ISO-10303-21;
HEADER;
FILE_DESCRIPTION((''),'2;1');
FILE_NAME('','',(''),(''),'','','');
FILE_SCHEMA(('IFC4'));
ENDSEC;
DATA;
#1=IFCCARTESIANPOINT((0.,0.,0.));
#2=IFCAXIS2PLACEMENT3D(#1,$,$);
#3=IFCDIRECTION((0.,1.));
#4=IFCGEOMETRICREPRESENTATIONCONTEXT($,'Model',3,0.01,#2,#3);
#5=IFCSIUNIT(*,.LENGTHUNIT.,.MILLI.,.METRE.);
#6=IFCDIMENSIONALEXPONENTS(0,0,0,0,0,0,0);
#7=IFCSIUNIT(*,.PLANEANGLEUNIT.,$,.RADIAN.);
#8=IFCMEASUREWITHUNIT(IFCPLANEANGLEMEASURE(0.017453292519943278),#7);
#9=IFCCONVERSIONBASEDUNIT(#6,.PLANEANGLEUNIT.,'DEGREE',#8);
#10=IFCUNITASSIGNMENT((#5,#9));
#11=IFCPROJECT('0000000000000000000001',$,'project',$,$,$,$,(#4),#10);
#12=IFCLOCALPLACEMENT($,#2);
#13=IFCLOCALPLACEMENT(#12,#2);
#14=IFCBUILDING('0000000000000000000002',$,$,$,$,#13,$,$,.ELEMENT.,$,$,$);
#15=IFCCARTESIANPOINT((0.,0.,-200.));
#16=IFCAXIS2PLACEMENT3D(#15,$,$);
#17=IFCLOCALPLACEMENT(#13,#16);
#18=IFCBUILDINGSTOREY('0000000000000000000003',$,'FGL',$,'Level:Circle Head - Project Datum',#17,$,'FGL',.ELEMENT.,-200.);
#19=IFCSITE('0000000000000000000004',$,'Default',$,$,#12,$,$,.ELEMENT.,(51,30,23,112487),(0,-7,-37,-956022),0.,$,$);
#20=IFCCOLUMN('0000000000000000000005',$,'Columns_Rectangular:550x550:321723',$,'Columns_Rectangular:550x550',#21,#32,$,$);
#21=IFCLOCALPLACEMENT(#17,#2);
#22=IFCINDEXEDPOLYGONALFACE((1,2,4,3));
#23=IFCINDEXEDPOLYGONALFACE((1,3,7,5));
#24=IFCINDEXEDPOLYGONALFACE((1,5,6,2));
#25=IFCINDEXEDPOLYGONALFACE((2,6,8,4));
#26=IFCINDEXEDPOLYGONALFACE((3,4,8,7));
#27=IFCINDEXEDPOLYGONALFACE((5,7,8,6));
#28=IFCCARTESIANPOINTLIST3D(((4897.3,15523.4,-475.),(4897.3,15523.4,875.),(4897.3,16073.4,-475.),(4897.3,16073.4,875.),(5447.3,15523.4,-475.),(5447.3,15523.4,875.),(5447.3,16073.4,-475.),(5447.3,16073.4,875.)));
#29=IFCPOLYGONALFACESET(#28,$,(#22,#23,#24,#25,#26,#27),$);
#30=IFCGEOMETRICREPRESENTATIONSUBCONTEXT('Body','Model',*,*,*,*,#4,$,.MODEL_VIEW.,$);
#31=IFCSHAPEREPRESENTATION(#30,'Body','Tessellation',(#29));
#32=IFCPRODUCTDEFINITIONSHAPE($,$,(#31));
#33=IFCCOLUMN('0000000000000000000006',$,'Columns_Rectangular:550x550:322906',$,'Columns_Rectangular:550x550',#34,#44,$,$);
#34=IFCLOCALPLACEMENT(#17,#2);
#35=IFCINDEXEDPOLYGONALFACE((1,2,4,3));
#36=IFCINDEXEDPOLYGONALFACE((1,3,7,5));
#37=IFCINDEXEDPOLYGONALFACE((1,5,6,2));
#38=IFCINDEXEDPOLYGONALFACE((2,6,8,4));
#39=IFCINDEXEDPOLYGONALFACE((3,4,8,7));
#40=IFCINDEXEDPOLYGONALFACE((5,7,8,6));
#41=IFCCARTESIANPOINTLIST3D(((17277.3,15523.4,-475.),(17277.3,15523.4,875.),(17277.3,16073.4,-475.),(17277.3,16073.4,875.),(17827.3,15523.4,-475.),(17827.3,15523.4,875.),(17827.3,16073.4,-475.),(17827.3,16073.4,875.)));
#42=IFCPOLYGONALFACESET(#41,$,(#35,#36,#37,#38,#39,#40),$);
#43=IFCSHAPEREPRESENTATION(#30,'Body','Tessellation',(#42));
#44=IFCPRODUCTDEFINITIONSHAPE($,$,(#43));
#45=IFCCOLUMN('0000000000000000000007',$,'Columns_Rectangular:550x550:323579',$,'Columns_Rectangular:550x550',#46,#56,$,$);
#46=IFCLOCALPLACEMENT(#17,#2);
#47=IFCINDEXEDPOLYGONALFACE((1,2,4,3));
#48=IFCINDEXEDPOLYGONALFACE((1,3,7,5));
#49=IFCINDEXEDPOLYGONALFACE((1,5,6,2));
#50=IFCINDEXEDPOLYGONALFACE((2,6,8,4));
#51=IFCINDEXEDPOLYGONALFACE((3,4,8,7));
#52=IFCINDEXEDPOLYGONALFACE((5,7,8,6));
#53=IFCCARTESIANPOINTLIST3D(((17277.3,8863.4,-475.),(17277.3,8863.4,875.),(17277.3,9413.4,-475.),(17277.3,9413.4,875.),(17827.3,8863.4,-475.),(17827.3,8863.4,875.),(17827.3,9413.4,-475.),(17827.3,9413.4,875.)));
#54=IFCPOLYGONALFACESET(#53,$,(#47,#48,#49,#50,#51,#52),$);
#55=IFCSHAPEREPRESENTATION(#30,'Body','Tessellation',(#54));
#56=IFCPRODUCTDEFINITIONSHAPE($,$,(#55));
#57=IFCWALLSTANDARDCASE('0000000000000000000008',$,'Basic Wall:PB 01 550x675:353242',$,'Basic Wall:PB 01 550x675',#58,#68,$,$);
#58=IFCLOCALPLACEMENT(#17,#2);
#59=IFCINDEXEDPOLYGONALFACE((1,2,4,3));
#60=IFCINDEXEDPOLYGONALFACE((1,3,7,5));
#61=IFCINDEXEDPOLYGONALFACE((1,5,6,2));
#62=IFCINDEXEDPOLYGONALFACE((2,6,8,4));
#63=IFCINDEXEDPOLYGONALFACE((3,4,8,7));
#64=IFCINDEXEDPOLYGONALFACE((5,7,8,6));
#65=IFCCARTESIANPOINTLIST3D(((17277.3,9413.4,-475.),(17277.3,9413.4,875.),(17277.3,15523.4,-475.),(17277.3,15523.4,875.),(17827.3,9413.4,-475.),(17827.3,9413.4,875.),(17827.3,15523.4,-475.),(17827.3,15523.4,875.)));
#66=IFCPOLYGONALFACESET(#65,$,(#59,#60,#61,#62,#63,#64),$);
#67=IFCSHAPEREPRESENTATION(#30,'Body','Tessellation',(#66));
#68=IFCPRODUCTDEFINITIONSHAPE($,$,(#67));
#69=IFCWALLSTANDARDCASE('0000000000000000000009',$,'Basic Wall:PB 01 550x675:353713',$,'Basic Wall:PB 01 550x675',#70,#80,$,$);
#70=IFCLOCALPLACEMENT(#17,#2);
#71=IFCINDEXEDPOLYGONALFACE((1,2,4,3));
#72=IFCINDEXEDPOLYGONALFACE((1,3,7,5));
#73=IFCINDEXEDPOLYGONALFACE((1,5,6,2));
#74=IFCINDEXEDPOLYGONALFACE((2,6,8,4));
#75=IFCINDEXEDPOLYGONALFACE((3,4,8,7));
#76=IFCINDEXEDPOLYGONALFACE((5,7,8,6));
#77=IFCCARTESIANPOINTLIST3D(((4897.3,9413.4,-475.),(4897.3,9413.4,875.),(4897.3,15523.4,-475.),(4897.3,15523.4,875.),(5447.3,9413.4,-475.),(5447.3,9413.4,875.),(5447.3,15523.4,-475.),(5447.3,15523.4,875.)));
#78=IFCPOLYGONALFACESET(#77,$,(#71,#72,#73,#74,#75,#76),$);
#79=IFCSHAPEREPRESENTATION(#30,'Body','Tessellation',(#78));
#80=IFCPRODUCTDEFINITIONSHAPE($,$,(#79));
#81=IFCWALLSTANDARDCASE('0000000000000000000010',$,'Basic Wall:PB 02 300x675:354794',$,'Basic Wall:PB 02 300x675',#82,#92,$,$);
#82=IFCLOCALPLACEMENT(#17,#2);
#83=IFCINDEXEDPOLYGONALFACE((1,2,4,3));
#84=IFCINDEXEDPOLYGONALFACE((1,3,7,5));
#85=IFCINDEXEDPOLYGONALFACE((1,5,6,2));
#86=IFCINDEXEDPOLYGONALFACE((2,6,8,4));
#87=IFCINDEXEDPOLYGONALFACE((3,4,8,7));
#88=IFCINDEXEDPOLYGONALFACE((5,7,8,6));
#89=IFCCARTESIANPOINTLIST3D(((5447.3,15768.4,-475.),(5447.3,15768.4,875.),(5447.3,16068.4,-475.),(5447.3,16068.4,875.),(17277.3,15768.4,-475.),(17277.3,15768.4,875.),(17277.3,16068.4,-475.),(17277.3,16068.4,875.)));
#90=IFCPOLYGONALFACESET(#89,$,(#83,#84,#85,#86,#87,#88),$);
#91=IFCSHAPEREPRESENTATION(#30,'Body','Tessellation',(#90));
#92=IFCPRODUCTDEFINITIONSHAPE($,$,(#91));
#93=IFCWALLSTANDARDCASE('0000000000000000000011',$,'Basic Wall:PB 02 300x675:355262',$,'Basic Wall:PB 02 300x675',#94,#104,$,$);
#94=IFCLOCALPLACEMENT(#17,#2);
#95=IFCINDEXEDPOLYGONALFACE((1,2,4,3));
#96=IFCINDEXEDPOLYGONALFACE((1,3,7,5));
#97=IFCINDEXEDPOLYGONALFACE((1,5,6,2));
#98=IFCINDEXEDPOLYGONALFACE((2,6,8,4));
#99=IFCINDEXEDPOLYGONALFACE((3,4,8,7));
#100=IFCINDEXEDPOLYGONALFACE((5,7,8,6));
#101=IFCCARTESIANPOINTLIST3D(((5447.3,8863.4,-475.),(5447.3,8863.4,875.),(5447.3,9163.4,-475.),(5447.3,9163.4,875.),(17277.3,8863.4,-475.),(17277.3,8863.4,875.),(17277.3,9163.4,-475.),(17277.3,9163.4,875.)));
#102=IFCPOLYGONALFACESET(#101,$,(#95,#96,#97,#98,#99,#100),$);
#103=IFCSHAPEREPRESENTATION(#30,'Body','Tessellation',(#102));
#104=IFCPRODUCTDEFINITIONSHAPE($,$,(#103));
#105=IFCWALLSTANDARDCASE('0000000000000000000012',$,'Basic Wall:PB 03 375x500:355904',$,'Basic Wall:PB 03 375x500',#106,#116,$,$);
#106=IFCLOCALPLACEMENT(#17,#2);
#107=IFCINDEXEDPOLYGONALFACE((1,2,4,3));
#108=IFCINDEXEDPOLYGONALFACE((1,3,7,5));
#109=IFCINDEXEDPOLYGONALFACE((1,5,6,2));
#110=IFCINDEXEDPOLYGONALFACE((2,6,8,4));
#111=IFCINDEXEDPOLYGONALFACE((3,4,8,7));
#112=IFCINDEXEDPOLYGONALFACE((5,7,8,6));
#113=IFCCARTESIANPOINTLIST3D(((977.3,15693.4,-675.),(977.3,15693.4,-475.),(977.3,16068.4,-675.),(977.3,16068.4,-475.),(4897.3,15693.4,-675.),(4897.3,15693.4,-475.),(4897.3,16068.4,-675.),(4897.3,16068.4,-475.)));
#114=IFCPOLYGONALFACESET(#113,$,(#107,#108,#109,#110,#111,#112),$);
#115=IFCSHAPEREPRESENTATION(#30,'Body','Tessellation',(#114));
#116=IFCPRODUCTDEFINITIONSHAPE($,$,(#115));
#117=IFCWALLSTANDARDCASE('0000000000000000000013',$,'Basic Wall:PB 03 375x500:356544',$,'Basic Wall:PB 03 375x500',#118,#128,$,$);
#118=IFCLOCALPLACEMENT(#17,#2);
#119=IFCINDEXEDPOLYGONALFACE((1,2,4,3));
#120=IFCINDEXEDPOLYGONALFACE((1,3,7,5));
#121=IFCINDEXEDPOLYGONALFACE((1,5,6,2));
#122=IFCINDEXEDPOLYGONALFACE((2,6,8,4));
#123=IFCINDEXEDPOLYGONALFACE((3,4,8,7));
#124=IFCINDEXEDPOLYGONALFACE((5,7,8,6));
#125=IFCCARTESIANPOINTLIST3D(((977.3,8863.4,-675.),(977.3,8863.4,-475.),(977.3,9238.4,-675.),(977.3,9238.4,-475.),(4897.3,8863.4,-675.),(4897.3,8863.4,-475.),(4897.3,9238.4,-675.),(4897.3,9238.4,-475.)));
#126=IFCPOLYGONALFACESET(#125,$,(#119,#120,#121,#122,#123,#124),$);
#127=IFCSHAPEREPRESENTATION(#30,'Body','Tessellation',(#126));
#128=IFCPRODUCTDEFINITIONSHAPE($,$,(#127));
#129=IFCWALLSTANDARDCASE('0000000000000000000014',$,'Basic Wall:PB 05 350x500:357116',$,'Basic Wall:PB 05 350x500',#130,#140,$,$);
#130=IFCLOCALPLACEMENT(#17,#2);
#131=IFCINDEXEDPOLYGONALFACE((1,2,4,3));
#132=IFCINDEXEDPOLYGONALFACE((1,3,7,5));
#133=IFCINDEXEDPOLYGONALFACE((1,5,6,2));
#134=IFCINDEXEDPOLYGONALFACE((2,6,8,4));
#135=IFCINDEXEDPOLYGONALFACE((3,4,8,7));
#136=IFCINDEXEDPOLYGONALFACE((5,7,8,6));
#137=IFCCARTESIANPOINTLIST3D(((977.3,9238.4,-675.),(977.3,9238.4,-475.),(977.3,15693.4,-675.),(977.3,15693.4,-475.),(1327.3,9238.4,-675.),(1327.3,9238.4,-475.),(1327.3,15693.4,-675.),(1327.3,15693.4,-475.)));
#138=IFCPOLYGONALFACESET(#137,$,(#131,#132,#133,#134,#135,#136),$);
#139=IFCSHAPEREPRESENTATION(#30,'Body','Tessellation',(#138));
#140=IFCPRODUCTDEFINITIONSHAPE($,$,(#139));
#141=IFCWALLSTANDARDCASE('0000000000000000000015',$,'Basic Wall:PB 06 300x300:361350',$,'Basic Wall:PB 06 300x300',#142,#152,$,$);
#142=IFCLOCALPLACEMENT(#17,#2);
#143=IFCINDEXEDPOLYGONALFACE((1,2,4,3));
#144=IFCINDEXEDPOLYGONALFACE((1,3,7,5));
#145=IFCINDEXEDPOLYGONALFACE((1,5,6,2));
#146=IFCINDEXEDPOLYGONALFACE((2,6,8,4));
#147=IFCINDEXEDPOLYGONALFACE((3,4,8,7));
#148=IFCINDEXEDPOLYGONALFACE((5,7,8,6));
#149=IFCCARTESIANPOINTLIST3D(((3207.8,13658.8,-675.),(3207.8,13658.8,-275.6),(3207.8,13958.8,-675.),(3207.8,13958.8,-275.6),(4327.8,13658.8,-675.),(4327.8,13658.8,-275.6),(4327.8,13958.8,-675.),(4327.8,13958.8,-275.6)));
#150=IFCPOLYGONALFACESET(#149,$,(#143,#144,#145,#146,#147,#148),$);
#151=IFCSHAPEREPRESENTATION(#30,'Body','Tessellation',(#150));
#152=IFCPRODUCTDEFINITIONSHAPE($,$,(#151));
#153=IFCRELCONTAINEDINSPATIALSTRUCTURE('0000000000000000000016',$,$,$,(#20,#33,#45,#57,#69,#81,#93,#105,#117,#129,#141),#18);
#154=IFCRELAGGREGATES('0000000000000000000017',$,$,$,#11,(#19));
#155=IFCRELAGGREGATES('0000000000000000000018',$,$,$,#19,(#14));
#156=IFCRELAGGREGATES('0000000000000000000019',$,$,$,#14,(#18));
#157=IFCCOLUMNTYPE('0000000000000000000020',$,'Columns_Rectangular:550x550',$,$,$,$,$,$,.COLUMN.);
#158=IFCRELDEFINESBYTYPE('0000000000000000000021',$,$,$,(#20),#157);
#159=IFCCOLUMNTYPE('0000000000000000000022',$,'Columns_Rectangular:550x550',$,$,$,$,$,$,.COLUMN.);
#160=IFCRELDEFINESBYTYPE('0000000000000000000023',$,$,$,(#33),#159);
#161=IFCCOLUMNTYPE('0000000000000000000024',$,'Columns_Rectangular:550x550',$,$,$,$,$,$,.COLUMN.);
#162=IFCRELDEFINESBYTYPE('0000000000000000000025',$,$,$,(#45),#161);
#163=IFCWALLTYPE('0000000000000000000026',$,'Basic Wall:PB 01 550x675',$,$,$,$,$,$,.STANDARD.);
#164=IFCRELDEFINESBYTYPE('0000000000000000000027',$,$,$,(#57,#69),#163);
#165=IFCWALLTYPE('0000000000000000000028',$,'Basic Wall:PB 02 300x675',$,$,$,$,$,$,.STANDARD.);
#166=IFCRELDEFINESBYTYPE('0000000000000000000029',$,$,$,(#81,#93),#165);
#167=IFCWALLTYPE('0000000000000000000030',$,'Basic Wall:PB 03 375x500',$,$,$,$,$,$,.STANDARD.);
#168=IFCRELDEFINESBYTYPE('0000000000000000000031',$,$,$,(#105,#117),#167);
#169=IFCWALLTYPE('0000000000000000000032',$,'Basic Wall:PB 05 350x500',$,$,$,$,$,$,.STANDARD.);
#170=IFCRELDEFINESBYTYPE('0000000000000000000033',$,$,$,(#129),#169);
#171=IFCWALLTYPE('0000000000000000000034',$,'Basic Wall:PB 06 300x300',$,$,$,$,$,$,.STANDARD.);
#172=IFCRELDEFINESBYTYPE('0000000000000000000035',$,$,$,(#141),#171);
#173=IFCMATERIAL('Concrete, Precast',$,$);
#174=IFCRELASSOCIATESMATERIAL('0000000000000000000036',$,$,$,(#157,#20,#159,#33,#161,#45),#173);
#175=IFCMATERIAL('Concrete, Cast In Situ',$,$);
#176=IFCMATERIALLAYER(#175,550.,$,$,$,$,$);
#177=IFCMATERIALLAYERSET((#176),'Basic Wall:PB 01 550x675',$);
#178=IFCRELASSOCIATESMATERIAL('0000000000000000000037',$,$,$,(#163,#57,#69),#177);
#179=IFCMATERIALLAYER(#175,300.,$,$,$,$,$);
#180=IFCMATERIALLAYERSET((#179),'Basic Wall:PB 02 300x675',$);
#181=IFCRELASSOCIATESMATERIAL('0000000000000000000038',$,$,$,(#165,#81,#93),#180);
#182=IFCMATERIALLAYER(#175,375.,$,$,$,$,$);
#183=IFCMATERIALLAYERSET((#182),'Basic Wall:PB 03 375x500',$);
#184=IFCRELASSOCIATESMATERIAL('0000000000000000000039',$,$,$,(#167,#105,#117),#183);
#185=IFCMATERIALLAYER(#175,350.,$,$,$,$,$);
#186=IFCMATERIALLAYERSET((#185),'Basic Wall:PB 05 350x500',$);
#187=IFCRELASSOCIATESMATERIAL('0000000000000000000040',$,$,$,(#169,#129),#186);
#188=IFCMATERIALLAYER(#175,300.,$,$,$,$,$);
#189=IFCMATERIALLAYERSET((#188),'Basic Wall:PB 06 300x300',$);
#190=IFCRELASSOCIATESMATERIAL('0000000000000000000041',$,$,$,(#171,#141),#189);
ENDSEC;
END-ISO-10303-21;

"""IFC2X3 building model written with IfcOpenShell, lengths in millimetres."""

from ifc_helpers import new_model, entity, si_unit, converted_unit, direction, frame, frame_2d, origin, place, context, subcontext, project, spatial, rectangle, extrude, source, transform, mapped, material, layer, layer_set, layer_usage, type_object, type_shapes, element, save


model = new_model("IFC2X3")

# Units and contexts
model_context = context("Model", 3, precision=0.01, world=origin(), true_north=direction((0.0, 1.0)))
body_context = subcontext(model_context, "Body", "Model", "MODEL_VIEW")
ifc_project = project(units=[si_unit("LENGTHUNIT", "METRE", prefix="MILLI"), converted_unit("PLANEANGLEUNIT", "DEGREE", entity("IfcPlaneAngleMeasure", 0.017453292519943278), si_unit("PLANEANGLEUNIT", "RADIAN"), dimensions=[0, 0, 0, 0, 0, 0, 0])], contexts=[model_context])

# Site, building, storey
site_placement = place(None, origin())
site = spatial("IfcSite", under=ifc_project, at=site_placement, Name="Default", CompositionType="ELEMENT", RefLatitude=(51, 30, 23, 112487), RefLongitude=(0, -7, -37, -956022), RefElevation=0.0)
building_placement = place(site_placement, origin())
building = spatial("IfcBuilding", under=site, at=building_placement, CompositionType="ELEMENT")
storey_placement = place(building_placement, frame((0.0, 0.0, -200.0)))
storey = spatial("IfcBuildingStorey", under=building, at=storey_placement, Name="FGL", ObjectType="Level:Circle Head - Project Datum", LongName="FGL", CompositionType="ELEMENT", Elevation=-200.0)

# Columns
ifc_material_1 = material(Name="Concrete, Precast")
column_type_1 = type_object("IfcColumnType", Name="Columns_Rectangular:550x550", PredefinedType="COLUMN", material=ifc_material_1)
shared_shape_1 = source(origin(), body_context, "Body", "SweptSolid", [
    extrude(rectangle(XDim=550.0, YDim=550.0, at=frame_2d((0.0, 0.0), x_axis=(1.0, 0.0))), frame((5172.3, 15798.4, -675.0), z_axis=(0.0, 0.0, 1.0), x_axis=(-1.0, 0.0, 0.0)), (0.0, 0.0, 1.0), 1350.0),
])
type_shapes(column_type_1, [shared_shape_1])
column_1_placement = place(storey_placement, frame((0.0, 0.0, 200.0)))
element("IfcColumn", 1, at=column_1_placement, inside=storey, type_object=column_type_1, material=ifc_material_1, Name="Columns_Rectangular:550x550:321723", ObjectType="Columns_Rectangular:550x550", context=body_context, shape_type="MappedRepresentation", body=[
    mapped(shared_shape_1, transform((0.0, 0.0, 0.0), scale=1.0)),
])
column_type_2 = type_object("IfcColumnType", Name="Columns_Rectangular:550x550", PredefinedType="COLUMN", material=ifc_material_1)
shared_shape_2 = source(origin(), body_context, "Body", "SweptSolid", [
    extrude(rectangle(XDim=550.0, YDim=550.0, at=frame_2d((0.0, 0.0), x_axis=(1.0, 0.0))), frame((17552.3, 15798.4, -675.0), z_axis=(0.0, 0.0, 1.0), x_axis=(-1.0, 0.0, 0.0)), (0.0, 0.0, 1.0), 1350.0),
])
type_shapes(column_type_2, [shared_shape_2])
column_2_placement = place(storey_placement, frame((0.0, 0.0, 200.0)))
element("IfcColumn", 2, at=column_2_placement, inside=storey, type_object=column_type_2, material=ifc_material_1, Name="Columns_Rectangular:550x550:322906", ObjectType="Columns_Rectangular:550x550", context=body_context, shape_type="MappedRepresentation", body=[
    mapped(shared_shape_2, transform((0.0, 0.0, 0.0), scale=1.0)),
])
column_type_3 = type_object("IfcColumnType", Name="Columns_Rectangular:550x550", PredefinedType="COLUMN", material=ifc_material_1)
shared_shape_3 = source(origin(), body_context, "Body", "SweptSolid", [
    extrude(rectangle(XDim=550.0, YDim=550.0, at=frame_2d((0.0, 0.0), x_axis=(1.0, 0.0))), frame((17552.3, 9138.4, -675.0), z_axis=(0.0, 0.0, 1.0), x_axis=(-1.0, 0.0, 0.0)), (0.0, 0.0, 1.0), 1350.0),
])
type_shapes(column_type_3, [shared_shape_3])
column_3_placement = place(storey_placement, frame((0.0, 0.0, 200.0)))
element("IfcColumn", 3, at=column_3_placement, inside=storey, type_object=column_type_3, material=ifc_material_1, Name="Columns_Rectangular:550x550:323579", ObjectType="Columns_Rectangular:550x550", context=body_context, shape_type="MappedRepresentation", body=[
    mapped(shared_shape_3, transform((0.0, 0.0, 0.0), scale=1.0)),
])

# Walls
ifc_material_2 = material(Name="Concrete, Cast In Situ")
ifc_layer_1 = layer(ifc_material_2, 550.0)
ifc_layer_set_1 = layer_set([ifc_layer_1], Name="Basic Wall:PB 01 550x675")
ifc_layer_usage_1 = layer_usage(ifc_layer_set_1, "AXIS2", "NEGATIVE", 275.0)
wall_type_1 = type_object("IfcWallType", Name="Basic Wall:PB 01 550x675", PredefinedType="STANDARD", material=ifc_layer_set_1)
wall_1_placement = place(storey_placement, frame((17552.3, 15523.4, -475.0), z_axis=(0.0, 0.0, 1.0), x_axis=(0.0, -1.0, 0.0)))
element("IfcWallStandardCase", 4, at=wall_1_placement, inside=storey, type_object=wall_type_1, material=ifc_layer_usage_1, Name="Basic Wall:PB 01 550x675:353242", ObjectType="Basic Wall:PB 01 550x675", context=body_context, shape_type="SweptSolid", body=[
    extrude(rectangle(XDim=6110.0, YDim=550.0, at=frame_2d((3055.0, 0.0), x_axis=(-1.0, 0.0))), origin(), (0.0, 0.0, 1.0), 1350.0),
])
ifc_layer_usage_2 = layer_usage(ifc_layer_set_1, "AXIS2", "NEGATIVE", 275.0)
wall_2_placement = place(storey_placement, frame((5172.3, 15523.4, -475.0), z_axis=(0.0, 0.0, 1.0), x_axis=(0.0, -1.0, 0.0)))
element("IfcWallStandardCase", 5, at=wall_2_placement, inside=storey, type_object=wall_type_1, material=ifc_layer_usage_2, Name="Basic Wall:PB 01 550x675:353713", ObjectType="Basic Wall:PB 01 550x675", context=body_context, shape_type="SweptSolid", body=[
    extrude(rectangle(XDim=6110.0, YDim=550.0, at=frame_2d((3055.0, 0.0), x_axis=(-1.0, 0.0))), origin(), (0.0, 0.0, 1.0), 1350.0),
])
ifc_layer_2 = layer(ifc_material_2, 300.0)
ifc_layer_set_2 = layer_set([ifc_layer_2], Name="Basic Wall:PB 02 300x675")
ifc_layer_usage_3 = layer_usage(ifc_layer_set_2, "AXIS2", "NEGATIVE", 150.0)
wall_type_2 = type_object("IfcWallType", Name="Basic Wall:PB 02 300x675", PredefinedType="STANDARD", material=ifc_layer_set_2)
wall_3_placement = place(storey_placement, frame((17277.3, 15918.4, -475.0), z_axis=(0.0, 0.0, 1.0), x_axis=(-1.0, 0.0, 0.0)))
element("IfcWallStandardCase", 6, at=wall_3_placement, inside=storey, type_object=wall_type_2, material=ifc_layer_usage_3, Name="Basic Wall:PB 02 300x675:354794", ObjectType="Basic Wall:PB 02 300x675", context=body_context, shape_type="SweptSolid", body=[
    extrude(rectangle(XDim=11830.0, YDim=300.0, at=frame_2d((5915.0, 0.0), x_axis=(-1.0, 0.0))), origin(), (0.0, 0.0, 1.0), 1350.0),
])
ifc_layer_usage_4 = layer_usage(ifc_layer_set_2, "AXIS2", "NEGATIVE", 150.0)
wall_4_placement = place(storey_placement, frame((17277.3, 9013.4, -475.0), z_axis=(0.0, 0.0, 1.0), x_axis=(-1.0, 0.0, 0.0)))
element("IfcWallStandardCase", 7, at=wall_4_placement, inside=storey, type_object=wall_type_2, material=ifc_layer_usage_4, Name="Basic Wall:PB 02 300x675:355262", ObjectType="Basic Wall:PB 02 300x675", context=body_context, shape_type="SweptSolid", body=[
    extrude(rectangle(XDim=11830.0, YDim=300.0, at=frame_2d((5915.0, 0.0), x_axis=(-1.0, 0.0))), origin(), (0.0, 0.0, 1.0), 1350.0),
])
ifc_layer_3 = layer(ifc_material_2, 375.0)
ifc_layer_set_3 = layer_set([ifc_layer_3], Name="Basic Wall:PB 03 375x500")
ifc_layer_usage_5 = layer_usage(ifc_layer_set_3, "AXIS2", "NEGATIVE", 187.5)
wall_type_3 = type_object("IfcWallType", Name="Basic Wall:PB 03 375x500", PredefinedType="STANDARD", material=ifc_layer_set_3)
wall_5_placement = place(storey_placement, frame((4897.3, 15880.9, -675.0), z_axis=(0.0, 0.0, 1.0), x_axis=(-1.0, 0.0, 0.0)))
element("IfcWallStandardCase", 8, at=wall_5_placement, inside=storey, type_object=wall_type_3, material=ifc_layer_usage_5, Name="Basic Wall:PB 03 375x500:355904", ObjectType="Basic Wall:PB 03 375x500", context=body_context, shape_type="SweptSolid", body=[
    extrude(rectangle(XDim=3920.0, YDim=375.0, at=frame_2d((1960.0, 0.0), x_axis=(-1.0, 0.0))), origin(), (0.0, 0.0, 1.0), 200.0),
])
ifc_layer_usage_6 = layer_usage(ifc_layer_set_3, "AXIS2", "NEGATIVE", 187.5)
wall_6_placement = place(storey_placement, frame((4897.3, 9050.9, -675.0), z_axis=(0.0, 0.0, 1.0), x_axis=(-1.0, 0.0, 0.0)))
element("IfcWallStandardCase", 9, at=wall_6_placement, inside=storey, type_object=wall_type_3, material=ifc_layer_usage_6, Name="Basic Wall:PB 03 375x500:356544", ObjectType="Basic Wall:PB 03 375x500", context=body_context, shape_type="SweptSolid", body=[
    extrude(rectangle(XDim=3920.0, YDim=375.0, at=frame_2d((1960.0, 0.0), x_axis=(-1.0, 0.0))), origin(), (0.0, 0.0, 1.0), 200.0),
])
ifc_layer_4 = layer(ifc_material_2, 350.0)
ifc_layer_set_4 = layer_set([ifc_layer_4], Name="Basic Wall:PB 05 350x500")
ifc_layer_usage_7 = layer_usage(ifc_layer_set_4, "AXIS2", "NEGATIVE", 175.0)
wall_type_4 = type_object("IfcWallType", Name="Basic Wall:PB 05 350x500", PredefinedType="STANDARD", material=ifc_layer_set_4)
wall_7_placement = place(storey_placement, frame((1152.3, 15693.4, -675.0), z_axis=(0.0, 0.0, 1.0), x_axis=(0.0, -1.0, 0.0)))
element("IfcWallStandardCase", 10, at=wall_7_placement, inside=storey, type_object=wall_type_4, material=ifc_layer_usage_7, Name="Basic Wall:PB 05 350x500:357116", ObjectType="Basic Wall:PB 05 350x500", context=body_context, shape_type="SweptSolid", body=[
    extrude(rectangle(XDim=6455.0, YDim=350.0, at=frame_2d((3227.5, 0.0), x_axis=(-1.0, 0.0))), origin(), (0.0, 0.0, 1.0), 200.0),
])
ifc_layer_5 = layer(ifc_material_2, 300.0)
ifc_layer_set_5 = layer_set([ifc_layer_5], Name="Basic Wall:PB 06 300x300")
ifc_layer_usage_8 = layer_usage(ifc_layer_set_5, "AXIS2", "NEGATIVE", 150.0)
wall_type_5 = type_object("IfcWallType", Name="Basic Wall:PB 06 300x300", PredefinedType="STANDARD", material=ifc_layer_set_5)
wall_8_placement = place(storey_placement, frame((3207.8, 13808.8, -675.0)))
element("IfcWallStandardCase", 11, at=wall_8_placement, inside=storey, type_object=wall_type_5, material=ifc_layer_usage_8, Name="Basic Wall:PB 06 300x300:361350", ObjectType="Basic Wall:PB 06 300x300", context=body_context, shape_type="SweptSolid", body=[
    extrude(rectangle(XDim=1120.0, YDim=300.0, at=frame_2d((560.0, 0.0), x_axis=(-1.0, 0.0))), origin(), (0.0, 0.0, 1.0), 399.4),
])

save(model, "model.ifc")
